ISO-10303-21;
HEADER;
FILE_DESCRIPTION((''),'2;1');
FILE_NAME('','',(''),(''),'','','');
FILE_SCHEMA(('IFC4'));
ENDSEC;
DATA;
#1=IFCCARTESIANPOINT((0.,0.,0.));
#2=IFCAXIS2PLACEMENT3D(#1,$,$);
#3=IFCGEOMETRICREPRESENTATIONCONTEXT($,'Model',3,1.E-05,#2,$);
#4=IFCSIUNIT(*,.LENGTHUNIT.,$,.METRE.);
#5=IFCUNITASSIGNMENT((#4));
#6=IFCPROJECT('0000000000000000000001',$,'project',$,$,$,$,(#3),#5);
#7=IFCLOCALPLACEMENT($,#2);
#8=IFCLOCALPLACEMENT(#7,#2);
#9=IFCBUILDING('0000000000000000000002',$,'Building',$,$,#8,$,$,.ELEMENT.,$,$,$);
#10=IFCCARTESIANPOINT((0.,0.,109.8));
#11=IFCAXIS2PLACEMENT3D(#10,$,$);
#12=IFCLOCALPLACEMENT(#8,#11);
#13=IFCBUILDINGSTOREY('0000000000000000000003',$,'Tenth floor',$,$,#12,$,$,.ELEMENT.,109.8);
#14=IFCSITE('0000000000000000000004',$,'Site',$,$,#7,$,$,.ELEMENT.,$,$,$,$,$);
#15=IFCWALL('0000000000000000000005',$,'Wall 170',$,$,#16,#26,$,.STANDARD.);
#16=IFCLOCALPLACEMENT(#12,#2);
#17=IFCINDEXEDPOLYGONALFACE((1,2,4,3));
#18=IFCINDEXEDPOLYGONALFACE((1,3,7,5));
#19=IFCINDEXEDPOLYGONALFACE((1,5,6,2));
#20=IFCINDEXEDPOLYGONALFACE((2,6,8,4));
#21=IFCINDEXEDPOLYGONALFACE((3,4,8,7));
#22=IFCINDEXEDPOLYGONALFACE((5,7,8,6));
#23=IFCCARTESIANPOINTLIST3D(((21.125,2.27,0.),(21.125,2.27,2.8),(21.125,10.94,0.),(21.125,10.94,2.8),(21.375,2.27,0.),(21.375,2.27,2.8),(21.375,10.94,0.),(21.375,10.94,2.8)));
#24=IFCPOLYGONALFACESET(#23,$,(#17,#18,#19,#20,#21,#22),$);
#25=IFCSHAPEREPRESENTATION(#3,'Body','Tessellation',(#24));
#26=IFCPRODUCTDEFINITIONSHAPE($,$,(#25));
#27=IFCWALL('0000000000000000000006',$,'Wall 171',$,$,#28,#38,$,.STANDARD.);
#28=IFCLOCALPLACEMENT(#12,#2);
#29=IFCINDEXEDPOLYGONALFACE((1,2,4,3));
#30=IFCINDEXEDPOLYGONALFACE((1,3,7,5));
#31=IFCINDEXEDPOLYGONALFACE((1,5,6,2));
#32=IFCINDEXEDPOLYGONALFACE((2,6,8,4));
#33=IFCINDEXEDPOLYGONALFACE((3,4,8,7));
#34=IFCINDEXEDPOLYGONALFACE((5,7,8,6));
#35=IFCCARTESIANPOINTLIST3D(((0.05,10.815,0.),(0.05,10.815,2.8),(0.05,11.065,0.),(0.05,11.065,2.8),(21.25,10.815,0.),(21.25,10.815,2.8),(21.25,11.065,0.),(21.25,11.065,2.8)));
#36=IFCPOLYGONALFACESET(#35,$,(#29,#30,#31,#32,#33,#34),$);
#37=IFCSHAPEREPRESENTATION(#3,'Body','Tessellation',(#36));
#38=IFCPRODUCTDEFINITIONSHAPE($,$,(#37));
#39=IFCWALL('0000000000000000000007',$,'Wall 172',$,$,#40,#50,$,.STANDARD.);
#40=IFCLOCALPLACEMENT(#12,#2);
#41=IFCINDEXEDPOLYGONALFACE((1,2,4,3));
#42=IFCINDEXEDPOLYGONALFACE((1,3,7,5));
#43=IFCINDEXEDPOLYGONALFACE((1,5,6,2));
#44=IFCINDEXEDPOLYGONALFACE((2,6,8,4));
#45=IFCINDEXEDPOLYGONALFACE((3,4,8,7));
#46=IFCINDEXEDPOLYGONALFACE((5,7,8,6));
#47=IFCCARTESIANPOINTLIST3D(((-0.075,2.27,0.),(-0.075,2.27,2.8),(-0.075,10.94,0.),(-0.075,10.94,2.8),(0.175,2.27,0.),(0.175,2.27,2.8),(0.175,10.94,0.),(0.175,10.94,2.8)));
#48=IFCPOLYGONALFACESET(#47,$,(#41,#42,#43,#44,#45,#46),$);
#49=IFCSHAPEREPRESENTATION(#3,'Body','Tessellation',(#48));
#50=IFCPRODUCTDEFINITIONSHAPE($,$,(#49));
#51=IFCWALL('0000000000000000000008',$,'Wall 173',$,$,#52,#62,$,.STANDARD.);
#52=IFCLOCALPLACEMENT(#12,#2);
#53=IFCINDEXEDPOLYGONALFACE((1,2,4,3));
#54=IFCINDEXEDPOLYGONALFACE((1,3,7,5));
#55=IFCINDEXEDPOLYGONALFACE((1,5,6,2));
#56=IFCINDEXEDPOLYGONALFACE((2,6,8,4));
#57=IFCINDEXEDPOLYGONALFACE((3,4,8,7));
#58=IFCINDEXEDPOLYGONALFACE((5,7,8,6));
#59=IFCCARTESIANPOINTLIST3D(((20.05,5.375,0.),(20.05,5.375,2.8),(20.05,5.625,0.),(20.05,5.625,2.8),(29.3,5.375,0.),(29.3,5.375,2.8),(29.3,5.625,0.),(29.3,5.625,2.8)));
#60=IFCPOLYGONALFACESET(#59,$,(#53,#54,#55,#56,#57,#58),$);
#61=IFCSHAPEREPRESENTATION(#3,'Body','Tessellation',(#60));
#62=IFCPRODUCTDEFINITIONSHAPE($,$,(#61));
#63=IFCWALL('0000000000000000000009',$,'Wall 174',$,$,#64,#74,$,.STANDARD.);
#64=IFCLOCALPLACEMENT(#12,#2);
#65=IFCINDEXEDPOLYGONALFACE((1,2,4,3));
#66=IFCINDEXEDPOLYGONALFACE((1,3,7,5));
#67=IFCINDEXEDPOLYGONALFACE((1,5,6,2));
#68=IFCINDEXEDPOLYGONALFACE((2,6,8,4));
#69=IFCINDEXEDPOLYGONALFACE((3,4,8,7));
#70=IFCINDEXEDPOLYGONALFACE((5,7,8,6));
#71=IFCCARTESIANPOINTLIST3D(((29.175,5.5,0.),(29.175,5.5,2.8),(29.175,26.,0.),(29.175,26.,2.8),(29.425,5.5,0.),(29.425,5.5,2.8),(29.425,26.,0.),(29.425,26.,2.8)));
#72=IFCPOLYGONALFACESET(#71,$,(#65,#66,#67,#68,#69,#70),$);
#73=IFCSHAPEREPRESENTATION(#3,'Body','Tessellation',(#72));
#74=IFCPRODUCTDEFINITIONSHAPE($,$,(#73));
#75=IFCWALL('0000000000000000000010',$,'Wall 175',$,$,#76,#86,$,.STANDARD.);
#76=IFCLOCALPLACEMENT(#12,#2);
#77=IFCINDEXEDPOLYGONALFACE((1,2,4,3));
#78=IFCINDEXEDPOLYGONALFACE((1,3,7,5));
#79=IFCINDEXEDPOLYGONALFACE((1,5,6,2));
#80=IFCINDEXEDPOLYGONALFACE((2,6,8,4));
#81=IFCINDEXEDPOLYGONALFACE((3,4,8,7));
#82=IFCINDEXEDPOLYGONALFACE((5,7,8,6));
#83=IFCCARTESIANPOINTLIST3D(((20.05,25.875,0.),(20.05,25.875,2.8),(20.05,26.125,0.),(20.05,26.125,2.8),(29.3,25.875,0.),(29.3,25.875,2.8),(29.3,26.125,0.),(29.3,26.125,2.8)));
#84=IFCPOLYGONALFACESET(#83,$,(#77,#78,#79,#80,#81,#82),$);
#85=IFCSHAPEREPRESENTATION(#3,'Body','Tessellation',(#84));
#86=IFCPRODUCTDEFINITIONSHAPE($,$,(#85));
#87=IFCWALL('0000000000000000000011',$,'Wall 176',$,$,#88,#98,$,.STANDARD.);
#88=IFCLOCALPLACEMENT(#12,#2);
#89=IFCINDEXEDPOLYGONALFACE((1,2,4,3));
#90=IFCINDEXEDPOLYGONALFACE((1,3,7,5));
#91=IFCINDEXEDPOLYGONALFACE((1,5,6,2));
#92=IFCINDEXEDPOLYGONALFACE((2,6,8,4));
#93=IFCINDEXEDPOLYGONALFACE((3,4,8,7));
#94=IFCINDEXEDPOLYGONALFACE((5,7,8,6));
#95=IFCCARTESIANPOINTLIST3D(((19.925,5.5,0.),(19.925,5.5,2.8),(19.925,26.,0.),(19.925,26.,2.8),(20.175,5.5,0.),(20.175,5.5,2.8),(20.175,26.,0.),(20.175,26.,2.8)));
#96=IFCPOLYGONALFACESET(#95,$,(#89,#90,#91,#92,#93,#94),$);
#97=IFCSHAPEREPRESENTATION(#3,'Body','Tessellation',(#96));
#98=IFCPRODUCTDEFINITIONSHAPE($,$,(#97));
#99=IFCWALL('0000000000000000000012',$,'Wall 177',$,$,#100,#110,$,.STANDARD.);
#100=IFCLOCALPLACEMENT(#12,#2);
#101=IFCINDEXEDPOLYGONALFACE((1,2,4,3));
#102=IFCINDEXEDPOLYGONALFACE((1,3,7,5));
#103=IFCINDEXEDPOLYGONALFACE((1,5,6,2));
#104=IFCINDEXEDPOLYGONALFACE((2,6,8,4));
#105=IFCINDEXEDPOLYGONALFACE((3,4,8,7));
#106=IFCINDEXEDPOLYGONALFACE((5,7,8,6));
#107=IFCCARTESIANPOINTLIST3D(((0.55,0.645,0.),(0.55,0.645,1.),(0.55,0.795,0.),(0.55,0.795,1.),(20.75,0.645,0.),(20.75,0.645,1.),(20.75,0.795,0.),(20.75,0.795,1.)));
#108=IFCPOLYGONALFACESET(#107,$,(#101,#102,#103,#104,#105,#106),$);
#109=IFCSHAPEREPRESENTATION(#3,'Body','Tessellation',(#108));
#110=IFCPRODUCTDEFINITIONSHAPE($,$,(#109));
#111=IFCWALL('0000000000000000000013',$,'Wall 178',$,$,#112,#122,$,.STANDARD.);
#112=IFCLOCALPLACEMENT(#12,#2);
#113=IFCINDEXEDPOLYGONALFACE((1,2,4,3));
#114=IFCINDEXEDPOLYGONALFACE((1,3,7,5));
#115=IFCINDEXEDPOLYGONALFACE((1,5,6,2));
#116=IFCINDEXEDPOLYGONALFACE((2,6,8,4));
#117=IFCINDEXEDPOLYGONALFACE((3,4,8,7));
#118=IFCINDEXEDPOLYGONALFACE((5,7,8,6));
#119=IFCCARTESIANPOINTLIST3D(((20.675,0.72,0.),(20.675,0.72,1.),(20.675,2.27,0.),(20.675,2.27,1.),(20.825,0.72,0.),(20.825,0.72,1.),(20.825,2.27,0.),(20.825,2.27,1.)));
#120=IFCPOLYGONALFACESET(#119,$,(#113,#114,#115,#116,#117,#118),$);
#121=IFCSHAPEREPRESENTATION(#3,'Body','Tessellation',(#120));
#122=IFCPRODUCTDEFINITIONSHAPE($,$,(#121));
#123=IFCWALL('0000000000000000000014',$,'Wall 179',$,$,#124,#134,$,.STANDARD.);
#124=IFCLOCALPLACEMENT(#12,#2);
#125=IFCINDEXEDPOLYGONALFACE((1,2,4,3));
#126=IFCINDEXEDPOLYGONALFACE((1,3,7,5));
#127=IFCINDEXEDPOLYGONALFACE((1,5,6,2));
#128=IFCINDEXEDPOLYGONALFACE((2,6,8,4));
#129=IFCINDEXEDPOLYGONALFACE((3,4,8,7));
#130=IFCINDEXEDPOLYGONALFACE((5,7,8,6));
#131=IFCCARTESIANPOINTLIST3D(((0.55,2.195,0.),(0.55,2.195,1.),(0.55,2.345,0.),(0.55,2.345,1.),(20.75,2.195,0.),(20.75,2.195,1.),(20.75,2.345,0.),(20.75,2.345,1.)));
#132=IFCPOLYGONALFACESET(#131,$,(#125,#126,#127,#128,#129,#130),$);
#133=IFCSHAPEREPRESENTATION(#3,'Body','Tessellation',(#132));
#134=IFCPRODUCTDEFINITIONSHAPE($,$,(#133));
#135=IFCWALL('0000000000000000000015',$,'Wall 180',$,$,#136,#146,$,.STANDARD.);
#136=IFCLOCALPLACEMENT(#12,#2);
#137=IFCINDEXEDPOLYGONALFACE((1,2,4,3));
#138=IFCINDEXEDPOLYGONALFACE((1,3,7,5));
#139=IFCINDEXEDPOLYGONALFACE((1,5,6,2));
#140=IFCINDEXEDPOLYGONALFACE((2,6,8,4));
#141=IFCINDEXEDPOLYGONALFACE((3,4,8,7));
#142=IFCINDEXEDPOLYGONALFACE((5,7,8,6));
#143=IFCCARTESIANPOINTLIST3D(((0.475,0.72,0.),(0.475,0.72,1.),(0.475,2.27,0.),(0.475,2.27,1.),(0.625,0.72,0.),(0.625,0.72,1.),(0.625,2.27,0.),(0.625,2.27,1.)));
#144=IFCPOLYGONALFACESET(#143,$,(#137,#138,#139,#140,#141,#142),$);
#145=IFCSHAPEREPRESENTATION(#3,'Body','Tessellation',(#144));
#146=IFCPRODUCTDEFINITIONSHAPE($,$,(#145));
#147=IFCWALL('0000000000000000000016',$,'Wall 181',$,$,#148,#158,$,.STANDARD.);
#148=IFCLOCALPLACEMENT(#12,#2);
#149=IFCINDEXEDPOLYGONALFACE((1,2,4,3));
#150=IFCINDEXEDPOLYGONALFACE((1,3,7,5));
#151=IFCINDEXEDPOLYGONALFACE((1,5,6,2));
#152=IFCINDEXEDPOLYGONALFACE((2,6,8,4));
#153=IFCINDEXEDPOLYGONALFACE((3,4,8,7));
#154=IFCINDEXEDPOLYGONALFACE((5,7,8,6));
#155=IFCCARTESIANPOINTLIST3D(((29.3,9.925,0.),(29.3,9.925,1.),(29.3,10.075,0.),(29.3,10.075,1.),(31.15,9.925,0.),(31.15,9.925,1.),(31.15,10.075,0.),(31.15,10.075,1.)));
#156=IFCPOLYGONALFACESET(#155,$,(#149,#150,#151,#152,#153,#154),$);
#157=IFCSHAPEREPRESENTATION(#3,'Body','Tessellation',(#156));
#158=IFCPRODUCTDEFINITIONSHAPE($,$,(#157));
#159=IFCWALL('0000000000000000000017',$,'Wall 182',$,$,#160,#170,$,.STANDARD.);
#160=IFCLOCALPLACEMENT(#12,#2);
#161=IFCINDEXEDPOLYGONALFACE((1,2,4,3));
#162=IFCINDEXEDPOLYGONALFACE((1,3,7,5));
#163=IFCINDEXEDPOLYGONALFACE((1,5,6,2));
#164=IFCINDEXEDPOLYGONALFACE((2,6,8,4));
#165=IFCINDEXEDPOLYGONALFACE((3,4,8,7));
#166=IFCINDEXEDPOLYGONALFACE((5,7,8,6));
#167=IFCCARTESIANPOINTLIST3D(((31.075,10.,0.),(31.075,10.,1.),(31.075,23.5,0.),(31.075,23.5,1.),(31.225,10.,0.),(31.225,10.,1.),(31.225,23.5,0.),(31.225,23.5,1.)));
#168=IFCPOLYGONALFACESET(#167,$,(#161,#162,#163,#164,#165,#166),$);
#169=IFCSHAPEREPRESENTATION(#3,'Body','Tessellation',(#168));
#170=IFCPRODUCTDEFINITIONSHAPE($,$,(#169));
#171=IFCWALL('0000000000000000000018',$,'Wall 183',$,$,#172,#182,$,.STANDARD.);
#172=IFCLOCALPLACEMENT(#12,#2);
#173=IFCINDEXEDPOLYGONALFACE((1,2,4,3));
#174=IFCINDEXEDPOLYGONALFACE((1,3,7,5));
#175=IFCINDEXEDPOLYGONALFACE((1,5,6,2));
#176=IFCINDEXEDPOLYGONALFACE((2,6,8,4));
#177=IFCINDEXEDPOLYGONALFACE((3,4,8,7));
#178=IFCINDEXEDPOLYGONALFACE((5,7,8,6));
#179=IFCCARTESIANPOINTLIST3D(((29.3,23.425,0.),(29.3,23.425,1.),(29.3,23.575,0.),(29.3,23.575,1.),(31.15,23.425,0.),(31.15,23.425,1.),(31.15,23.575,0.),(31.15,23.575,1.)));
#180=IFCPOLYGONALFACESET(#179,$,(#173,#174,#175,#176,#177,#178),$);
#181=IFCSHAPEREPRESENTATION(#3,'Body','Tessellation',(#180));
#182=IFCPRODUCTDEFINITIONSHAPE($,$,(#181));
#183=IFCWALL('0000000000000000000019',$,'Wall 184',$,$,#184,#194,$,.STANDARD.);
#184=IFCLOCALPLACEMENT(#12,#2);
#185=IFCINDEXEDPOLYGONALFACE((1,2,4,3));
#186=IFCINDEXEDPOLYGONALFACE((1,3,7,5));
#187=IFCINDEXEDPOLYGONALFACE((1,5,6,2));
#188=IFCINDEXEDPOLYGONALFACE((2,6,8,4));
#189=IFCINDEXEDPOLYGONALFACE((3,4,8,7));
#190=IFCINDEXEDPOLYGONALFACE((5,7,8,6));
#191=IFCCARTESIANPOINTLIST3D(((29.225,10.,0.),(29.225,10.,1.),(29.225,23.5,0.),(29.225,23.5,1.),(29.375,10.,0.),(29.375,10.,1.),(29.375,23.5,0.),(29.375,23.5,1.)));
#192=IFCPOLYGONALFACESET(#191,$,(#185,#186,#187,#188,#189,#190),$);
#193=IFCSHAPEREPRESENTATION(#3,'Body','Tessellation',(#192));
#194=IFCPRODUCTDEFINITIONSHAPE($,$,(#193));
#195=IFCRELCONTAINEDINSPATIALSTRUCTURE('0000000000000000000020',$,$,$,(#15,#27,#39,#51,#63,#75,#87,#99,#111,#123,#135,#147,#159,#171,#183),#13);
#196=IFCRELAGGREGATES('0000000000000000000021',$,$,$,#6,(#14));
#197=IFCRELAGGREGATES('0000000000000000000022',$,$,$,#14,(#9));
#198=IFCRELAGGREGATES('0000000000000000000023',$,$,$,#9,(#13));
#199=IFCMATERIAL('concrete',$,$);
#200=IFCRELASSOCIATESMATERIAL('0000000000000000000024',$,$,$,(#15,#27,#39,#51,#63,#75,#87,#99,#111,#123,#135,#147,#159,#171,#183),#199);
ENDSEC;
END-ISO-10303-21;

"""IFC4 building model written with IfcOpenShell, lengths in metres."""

from ifc_helpers import new_model, si_unit, frame, frame_2d, origin, place, context, project, spatial, rectangle, extrude, material, element, save


model = new_model("IFC4")

# Units and contexts
model_context = context("Model", 3, precision=1e-05, world=origin())
ifc_project = project(units=[si_unit("LENGTHUNIT", "METRE")], contexts=[model_context])

# Site, building, storey
site_placement = place(None, origin())
site = spatial("IfcSite", under=ifc_project, at=site_placement, Name="Site", CompositionType="ELEMENT")
building_placement = place(site_placement, origin())
building = spatial("IfcBuilding", under=site, at=building_placement, Name="Building", CompositionType="ELEMENT")
storey_placement = place(building_placement, frame((0.0, 0.0, 109.8)))
storey = spatial("IfcBuildingStorey", under=building, at=storey_placement, Name="Tenth floor", CompositionType="ELEMENT", Elevation=109.8)

# Shared definitions
ifc_material = material(Name="concrete")

# Walls
wall_1_placement = place(storey_placement, frame((21.25, 2.27, 0.0), z_axis=(0.0, 0.0, 1.0), x_axis=(0.0, 1.0, 0.0)))
element("IfcWall", 1, at=wall_1_placement, inside=storey, material=ifc_material, Name="Wall 170", PredefinedType="STANDARD", context=model_context, shape_type="SweptSolid", body=[
    extrude(rectangle(XDim=8.67, YDim=0.25, at=frame_2d((4.335, 0.0))), origin(), (0.0, 0.0, 1.0), 2.8),
])
wall_2_placement = place(storey_placement, frame((21.25, 10.94, 0.0), z_axis=(0.0, 0.0, 1.0), x_axis=(-1.0, 0.0, 0.0)))
element("IfcWall", 2, at=wall_2_placement, inside=storey, material=ifc_material, Name="Wall 171", PredefinedType="STANDARD", context=model_context, shape_type="SweptSolid", body=[
    extrude(rectangle(XDim=21.2, YDim=0.25, at=frame_2d((10.6, 0.0))), origin(), (0.0, 0.0, 1.0), 2.8),
])
wall_3_placement = place(storey_placement, frame((0.05, 10.94, 0.0), z_axis=(0.0, 0.0, 1.0), x_axis=(0.0, -1.0, 0.0)))
element("IfcWall", 3, at=wall_3_placement, inside=storey, material=ifc_material, Name="Wall 172", PredefinedType="STANDARD", context=model_context, shape_type="SweptSolid", body=[
    extrude(rectangle(XDim=8.67, YDim=0.25, at=frame_2d((4.335, 0.0))), origin(), (0.0, 0.0, 1.0), 2.8),
])
wall_4_placement = place(storey_placement, frame((20.05, 5.5, 0.0), z_axis=(0.0, 0.0, 1.0), x_axis=(1.0, 0.0, 0.0)))
element("IfcWall", 4, at=wall_4_placement, inside=storey, material=ifc_material, Name="Wall 173", PredefinedType="STANDARD", context=model_context, shape_type="SweptSolid", body=[
    extrude(rectangle(XDim=9.25, YDim=0.25, at=frame_2d((4.625, 0.0))), origin(), (0.0, 0.0, 1.0), 2.8),
])
wall_5_placement = place(storey_placement, frame((29.3, 5.5, 0.0), z_axis=(0.0, 0.0, 1.0), x_axis=(0.0, 1.0, 0.0)))
element("IfcWall", 5, at=wall_5_placement, inside=storey, material=ifc_material, Name="Wall 174", PredefinedType="STANDARD", context=model_context, shape_type="SweptSolid", body=[
    extrude(rectangle(XDim=20.5, YDim=0.25, at=frame_2d((10.25, 0.0))), origin(), (0.0, 0.0, 1.0), 2.8),
])
wall_6_placement = place(storey_placement, frame((29.3, 26.0, 0.0), z_axis=(0.0, 0.0, 1.0), x_axis=(-1.0, 0.0, 0.0)))
element("IfcWall", 6, at=wall_6_placement, inside=storey, material=ifc_material, Name="Wall 175", PredefinedType="STANDARD", context=model_context, shape_type="SweptSolid", body=[
    extrude(rectangle(XDim=9.25, YDim=0.25, at=frame_2d((4.625, 0.0))), origin(), (0.0, 0.0, 1.0), 2.8),
])
wall_7_placement = place(storey_placement, frame((20.05, 26.0, 0.0), z_axis=(0.0, 0.0, 1.0), x_axis=(0.0, -1.0, 0.0)))
element("IfcWall", 7, at=wall_7_placement, inside=storey, material=ifc_material, Name="Wall 176", PredefinedType="STANDARD", context=model_context, shape_type="SweptSolid", body=[
    extrude(rectangle(XDim=20.5, YDim=0.25, at=frame_2d((10.25, 0.0))), origin(), (0.0, 0.0, 1.0), 2.8),
])
wall_8_placement = place(storey_placement, frame((0.55, 0.72, 0.0), z_axis=(0.0, 0.0, 1.0), x_axis=(1.0, 0.0, 0.0)))
element("IfcWall", 8, at=wall_8_placement, inside=storey, material=ifc_material, Name="Wall 177", PredefinedType="STANDARD", context=model_context, shape_type="SweptSolid", body=[
    extrude(rectangle(XDim=20.2, YDim=0.15, at=frame_2d((10.1, 0.0))), origin(), (0.0, 0.0, 1.0), 1.0),
])
wall_9_placement = place(storey_placement, frame((20.75, 0.72, 0.0), z_axis=(0.0, 0.0, 1.0), x_axis=(0.0, 1.0, 0.0)))
element("IfcWall", 9, at=wall_9_placement, inside=storey, material=ifc_material, Name="Wall 178", PredefinedType="STANDARD", context=model_context, shape_type="SweptSolid", body=[
    extrude(rectangle(XDim=1.55, YDim=0.15, at=frame_2d((0.775, 0.0))), origin(), (0.0, 0.0, 1.0), 1.0),
])
wall_10_placement = place(storey_placement, frame((20.75, 2.27, 0.0), z_axis=(0.0, 0.0, 1.0), x_axis=(-1.0, 0.0, 0.0)))
element("IfcWall", 10, at=wall_10_placement, inside=storey, material=ifc_material, Name="Wall 179", PredefinedType="STANDARD", context=model_context, shape_type="SweptSolid", body=[
    extrude(rectangle(XDim=20.2, YDim=0.15, at=frame_2d((10.1, 0.0))), origin(), (0.0, 0.0, 1.0), 1.0),
])
wall_11_placement = place(storey_placement, frame((0.55, 2.27, 0.0), z_axis=(0.0, 0.0, 1.0), x_axis=(0.0, -1.0, 0.0)))
element("IfcWall", 11, at=wall_11_placement, inside=storey, material=ifc_material, Name="Wall 180", PredefinedType="STANDARD", context=model_context, shape_type="SweptSolid", body=[
    extrude(rectangle(XDim=1.55, YDim=0.15, at=frame_2d((0.775, 0.0))), origin(), (0.0, 0.0, 1.0), 1.0),
])
wall_12_placement = place(storey_placement, frame((29.3, 10.0, 0.0), z_axis=(0.0, 0.0, 1.0), x_axis=(1.0, 0.0, 0.0)))
element("IfcWall", 12, at=wall_12_placement, inside=storey, material=ifc_material, Name="Wall 181", PredefinedType="STANDARD", context=model_context, shape_type="SweptSolid", body=[
    extrude(rectangle(XDim=1.85, YDim=0.15, at=frame_2d((0.925, 0.0))), origin(), (0.0, 0.0, 1.0), 1.0),
])
wall_13_placement = place(storey_placement, frame((31.15, 10.0, 0.0), z_axis=(0.0, 0.0, 1.0), x_axis=(0.0, 1.0, 0.0)))
element("IfcWall", 13, at=wall_13_placement, inside=storey, material=ifc_material, Name="Wall 182", PredefinedType="STANDARD", context=model_context, shape_type="SweptSolid", body=[
    extrude(rectangle(XDim=13.5, YDim=0.15, at=frame_2d((6.75, 0.0))), origin(), (0.0, 0.0, 1.0), 1.0),
])
wall_14_placement = place(storey_placement, frame((31.15, 23.5, 0.0), z_axis=(0.0, 0.0, 1.0), x_axis=(-1.0, 0.0, 0.0)))
element("IfcWall", 14, at=wall_14_placement, inside=storey, material=ifc_material, Name="Wall 183", PredefinedType="STANDARD", context=model_context, shape_type="SweptSolid", body=[
    extrude(rectangle(XDim=1.85, YDim=0.15, at=frame_2d((0.925, 0.0))), origin(), (0.0, 0.0, 1.0), 1.0),
])
wall_15_placement = place(storey_placement, frame((29.3, 23.5, 0.0), z_axis=(0.0, 0.0, 1.0), x_axis=(0.0, -1.0, 0.0)))
element("IfcWall", 15, at=wall_15_placement, inside=storey, material=ifc_material, Name="Wall 184", PredefinedType="STANDARD", context=model_context, shape_type="SweptSolid", body=[
    extrude(rectangle(XDim=13.5, YDim=0.15, at=frame_2d((6.75, 0.0))), origin(), (0.0, 0.0, 1.0), 1.0),
])

save(model, "model.ifc")
